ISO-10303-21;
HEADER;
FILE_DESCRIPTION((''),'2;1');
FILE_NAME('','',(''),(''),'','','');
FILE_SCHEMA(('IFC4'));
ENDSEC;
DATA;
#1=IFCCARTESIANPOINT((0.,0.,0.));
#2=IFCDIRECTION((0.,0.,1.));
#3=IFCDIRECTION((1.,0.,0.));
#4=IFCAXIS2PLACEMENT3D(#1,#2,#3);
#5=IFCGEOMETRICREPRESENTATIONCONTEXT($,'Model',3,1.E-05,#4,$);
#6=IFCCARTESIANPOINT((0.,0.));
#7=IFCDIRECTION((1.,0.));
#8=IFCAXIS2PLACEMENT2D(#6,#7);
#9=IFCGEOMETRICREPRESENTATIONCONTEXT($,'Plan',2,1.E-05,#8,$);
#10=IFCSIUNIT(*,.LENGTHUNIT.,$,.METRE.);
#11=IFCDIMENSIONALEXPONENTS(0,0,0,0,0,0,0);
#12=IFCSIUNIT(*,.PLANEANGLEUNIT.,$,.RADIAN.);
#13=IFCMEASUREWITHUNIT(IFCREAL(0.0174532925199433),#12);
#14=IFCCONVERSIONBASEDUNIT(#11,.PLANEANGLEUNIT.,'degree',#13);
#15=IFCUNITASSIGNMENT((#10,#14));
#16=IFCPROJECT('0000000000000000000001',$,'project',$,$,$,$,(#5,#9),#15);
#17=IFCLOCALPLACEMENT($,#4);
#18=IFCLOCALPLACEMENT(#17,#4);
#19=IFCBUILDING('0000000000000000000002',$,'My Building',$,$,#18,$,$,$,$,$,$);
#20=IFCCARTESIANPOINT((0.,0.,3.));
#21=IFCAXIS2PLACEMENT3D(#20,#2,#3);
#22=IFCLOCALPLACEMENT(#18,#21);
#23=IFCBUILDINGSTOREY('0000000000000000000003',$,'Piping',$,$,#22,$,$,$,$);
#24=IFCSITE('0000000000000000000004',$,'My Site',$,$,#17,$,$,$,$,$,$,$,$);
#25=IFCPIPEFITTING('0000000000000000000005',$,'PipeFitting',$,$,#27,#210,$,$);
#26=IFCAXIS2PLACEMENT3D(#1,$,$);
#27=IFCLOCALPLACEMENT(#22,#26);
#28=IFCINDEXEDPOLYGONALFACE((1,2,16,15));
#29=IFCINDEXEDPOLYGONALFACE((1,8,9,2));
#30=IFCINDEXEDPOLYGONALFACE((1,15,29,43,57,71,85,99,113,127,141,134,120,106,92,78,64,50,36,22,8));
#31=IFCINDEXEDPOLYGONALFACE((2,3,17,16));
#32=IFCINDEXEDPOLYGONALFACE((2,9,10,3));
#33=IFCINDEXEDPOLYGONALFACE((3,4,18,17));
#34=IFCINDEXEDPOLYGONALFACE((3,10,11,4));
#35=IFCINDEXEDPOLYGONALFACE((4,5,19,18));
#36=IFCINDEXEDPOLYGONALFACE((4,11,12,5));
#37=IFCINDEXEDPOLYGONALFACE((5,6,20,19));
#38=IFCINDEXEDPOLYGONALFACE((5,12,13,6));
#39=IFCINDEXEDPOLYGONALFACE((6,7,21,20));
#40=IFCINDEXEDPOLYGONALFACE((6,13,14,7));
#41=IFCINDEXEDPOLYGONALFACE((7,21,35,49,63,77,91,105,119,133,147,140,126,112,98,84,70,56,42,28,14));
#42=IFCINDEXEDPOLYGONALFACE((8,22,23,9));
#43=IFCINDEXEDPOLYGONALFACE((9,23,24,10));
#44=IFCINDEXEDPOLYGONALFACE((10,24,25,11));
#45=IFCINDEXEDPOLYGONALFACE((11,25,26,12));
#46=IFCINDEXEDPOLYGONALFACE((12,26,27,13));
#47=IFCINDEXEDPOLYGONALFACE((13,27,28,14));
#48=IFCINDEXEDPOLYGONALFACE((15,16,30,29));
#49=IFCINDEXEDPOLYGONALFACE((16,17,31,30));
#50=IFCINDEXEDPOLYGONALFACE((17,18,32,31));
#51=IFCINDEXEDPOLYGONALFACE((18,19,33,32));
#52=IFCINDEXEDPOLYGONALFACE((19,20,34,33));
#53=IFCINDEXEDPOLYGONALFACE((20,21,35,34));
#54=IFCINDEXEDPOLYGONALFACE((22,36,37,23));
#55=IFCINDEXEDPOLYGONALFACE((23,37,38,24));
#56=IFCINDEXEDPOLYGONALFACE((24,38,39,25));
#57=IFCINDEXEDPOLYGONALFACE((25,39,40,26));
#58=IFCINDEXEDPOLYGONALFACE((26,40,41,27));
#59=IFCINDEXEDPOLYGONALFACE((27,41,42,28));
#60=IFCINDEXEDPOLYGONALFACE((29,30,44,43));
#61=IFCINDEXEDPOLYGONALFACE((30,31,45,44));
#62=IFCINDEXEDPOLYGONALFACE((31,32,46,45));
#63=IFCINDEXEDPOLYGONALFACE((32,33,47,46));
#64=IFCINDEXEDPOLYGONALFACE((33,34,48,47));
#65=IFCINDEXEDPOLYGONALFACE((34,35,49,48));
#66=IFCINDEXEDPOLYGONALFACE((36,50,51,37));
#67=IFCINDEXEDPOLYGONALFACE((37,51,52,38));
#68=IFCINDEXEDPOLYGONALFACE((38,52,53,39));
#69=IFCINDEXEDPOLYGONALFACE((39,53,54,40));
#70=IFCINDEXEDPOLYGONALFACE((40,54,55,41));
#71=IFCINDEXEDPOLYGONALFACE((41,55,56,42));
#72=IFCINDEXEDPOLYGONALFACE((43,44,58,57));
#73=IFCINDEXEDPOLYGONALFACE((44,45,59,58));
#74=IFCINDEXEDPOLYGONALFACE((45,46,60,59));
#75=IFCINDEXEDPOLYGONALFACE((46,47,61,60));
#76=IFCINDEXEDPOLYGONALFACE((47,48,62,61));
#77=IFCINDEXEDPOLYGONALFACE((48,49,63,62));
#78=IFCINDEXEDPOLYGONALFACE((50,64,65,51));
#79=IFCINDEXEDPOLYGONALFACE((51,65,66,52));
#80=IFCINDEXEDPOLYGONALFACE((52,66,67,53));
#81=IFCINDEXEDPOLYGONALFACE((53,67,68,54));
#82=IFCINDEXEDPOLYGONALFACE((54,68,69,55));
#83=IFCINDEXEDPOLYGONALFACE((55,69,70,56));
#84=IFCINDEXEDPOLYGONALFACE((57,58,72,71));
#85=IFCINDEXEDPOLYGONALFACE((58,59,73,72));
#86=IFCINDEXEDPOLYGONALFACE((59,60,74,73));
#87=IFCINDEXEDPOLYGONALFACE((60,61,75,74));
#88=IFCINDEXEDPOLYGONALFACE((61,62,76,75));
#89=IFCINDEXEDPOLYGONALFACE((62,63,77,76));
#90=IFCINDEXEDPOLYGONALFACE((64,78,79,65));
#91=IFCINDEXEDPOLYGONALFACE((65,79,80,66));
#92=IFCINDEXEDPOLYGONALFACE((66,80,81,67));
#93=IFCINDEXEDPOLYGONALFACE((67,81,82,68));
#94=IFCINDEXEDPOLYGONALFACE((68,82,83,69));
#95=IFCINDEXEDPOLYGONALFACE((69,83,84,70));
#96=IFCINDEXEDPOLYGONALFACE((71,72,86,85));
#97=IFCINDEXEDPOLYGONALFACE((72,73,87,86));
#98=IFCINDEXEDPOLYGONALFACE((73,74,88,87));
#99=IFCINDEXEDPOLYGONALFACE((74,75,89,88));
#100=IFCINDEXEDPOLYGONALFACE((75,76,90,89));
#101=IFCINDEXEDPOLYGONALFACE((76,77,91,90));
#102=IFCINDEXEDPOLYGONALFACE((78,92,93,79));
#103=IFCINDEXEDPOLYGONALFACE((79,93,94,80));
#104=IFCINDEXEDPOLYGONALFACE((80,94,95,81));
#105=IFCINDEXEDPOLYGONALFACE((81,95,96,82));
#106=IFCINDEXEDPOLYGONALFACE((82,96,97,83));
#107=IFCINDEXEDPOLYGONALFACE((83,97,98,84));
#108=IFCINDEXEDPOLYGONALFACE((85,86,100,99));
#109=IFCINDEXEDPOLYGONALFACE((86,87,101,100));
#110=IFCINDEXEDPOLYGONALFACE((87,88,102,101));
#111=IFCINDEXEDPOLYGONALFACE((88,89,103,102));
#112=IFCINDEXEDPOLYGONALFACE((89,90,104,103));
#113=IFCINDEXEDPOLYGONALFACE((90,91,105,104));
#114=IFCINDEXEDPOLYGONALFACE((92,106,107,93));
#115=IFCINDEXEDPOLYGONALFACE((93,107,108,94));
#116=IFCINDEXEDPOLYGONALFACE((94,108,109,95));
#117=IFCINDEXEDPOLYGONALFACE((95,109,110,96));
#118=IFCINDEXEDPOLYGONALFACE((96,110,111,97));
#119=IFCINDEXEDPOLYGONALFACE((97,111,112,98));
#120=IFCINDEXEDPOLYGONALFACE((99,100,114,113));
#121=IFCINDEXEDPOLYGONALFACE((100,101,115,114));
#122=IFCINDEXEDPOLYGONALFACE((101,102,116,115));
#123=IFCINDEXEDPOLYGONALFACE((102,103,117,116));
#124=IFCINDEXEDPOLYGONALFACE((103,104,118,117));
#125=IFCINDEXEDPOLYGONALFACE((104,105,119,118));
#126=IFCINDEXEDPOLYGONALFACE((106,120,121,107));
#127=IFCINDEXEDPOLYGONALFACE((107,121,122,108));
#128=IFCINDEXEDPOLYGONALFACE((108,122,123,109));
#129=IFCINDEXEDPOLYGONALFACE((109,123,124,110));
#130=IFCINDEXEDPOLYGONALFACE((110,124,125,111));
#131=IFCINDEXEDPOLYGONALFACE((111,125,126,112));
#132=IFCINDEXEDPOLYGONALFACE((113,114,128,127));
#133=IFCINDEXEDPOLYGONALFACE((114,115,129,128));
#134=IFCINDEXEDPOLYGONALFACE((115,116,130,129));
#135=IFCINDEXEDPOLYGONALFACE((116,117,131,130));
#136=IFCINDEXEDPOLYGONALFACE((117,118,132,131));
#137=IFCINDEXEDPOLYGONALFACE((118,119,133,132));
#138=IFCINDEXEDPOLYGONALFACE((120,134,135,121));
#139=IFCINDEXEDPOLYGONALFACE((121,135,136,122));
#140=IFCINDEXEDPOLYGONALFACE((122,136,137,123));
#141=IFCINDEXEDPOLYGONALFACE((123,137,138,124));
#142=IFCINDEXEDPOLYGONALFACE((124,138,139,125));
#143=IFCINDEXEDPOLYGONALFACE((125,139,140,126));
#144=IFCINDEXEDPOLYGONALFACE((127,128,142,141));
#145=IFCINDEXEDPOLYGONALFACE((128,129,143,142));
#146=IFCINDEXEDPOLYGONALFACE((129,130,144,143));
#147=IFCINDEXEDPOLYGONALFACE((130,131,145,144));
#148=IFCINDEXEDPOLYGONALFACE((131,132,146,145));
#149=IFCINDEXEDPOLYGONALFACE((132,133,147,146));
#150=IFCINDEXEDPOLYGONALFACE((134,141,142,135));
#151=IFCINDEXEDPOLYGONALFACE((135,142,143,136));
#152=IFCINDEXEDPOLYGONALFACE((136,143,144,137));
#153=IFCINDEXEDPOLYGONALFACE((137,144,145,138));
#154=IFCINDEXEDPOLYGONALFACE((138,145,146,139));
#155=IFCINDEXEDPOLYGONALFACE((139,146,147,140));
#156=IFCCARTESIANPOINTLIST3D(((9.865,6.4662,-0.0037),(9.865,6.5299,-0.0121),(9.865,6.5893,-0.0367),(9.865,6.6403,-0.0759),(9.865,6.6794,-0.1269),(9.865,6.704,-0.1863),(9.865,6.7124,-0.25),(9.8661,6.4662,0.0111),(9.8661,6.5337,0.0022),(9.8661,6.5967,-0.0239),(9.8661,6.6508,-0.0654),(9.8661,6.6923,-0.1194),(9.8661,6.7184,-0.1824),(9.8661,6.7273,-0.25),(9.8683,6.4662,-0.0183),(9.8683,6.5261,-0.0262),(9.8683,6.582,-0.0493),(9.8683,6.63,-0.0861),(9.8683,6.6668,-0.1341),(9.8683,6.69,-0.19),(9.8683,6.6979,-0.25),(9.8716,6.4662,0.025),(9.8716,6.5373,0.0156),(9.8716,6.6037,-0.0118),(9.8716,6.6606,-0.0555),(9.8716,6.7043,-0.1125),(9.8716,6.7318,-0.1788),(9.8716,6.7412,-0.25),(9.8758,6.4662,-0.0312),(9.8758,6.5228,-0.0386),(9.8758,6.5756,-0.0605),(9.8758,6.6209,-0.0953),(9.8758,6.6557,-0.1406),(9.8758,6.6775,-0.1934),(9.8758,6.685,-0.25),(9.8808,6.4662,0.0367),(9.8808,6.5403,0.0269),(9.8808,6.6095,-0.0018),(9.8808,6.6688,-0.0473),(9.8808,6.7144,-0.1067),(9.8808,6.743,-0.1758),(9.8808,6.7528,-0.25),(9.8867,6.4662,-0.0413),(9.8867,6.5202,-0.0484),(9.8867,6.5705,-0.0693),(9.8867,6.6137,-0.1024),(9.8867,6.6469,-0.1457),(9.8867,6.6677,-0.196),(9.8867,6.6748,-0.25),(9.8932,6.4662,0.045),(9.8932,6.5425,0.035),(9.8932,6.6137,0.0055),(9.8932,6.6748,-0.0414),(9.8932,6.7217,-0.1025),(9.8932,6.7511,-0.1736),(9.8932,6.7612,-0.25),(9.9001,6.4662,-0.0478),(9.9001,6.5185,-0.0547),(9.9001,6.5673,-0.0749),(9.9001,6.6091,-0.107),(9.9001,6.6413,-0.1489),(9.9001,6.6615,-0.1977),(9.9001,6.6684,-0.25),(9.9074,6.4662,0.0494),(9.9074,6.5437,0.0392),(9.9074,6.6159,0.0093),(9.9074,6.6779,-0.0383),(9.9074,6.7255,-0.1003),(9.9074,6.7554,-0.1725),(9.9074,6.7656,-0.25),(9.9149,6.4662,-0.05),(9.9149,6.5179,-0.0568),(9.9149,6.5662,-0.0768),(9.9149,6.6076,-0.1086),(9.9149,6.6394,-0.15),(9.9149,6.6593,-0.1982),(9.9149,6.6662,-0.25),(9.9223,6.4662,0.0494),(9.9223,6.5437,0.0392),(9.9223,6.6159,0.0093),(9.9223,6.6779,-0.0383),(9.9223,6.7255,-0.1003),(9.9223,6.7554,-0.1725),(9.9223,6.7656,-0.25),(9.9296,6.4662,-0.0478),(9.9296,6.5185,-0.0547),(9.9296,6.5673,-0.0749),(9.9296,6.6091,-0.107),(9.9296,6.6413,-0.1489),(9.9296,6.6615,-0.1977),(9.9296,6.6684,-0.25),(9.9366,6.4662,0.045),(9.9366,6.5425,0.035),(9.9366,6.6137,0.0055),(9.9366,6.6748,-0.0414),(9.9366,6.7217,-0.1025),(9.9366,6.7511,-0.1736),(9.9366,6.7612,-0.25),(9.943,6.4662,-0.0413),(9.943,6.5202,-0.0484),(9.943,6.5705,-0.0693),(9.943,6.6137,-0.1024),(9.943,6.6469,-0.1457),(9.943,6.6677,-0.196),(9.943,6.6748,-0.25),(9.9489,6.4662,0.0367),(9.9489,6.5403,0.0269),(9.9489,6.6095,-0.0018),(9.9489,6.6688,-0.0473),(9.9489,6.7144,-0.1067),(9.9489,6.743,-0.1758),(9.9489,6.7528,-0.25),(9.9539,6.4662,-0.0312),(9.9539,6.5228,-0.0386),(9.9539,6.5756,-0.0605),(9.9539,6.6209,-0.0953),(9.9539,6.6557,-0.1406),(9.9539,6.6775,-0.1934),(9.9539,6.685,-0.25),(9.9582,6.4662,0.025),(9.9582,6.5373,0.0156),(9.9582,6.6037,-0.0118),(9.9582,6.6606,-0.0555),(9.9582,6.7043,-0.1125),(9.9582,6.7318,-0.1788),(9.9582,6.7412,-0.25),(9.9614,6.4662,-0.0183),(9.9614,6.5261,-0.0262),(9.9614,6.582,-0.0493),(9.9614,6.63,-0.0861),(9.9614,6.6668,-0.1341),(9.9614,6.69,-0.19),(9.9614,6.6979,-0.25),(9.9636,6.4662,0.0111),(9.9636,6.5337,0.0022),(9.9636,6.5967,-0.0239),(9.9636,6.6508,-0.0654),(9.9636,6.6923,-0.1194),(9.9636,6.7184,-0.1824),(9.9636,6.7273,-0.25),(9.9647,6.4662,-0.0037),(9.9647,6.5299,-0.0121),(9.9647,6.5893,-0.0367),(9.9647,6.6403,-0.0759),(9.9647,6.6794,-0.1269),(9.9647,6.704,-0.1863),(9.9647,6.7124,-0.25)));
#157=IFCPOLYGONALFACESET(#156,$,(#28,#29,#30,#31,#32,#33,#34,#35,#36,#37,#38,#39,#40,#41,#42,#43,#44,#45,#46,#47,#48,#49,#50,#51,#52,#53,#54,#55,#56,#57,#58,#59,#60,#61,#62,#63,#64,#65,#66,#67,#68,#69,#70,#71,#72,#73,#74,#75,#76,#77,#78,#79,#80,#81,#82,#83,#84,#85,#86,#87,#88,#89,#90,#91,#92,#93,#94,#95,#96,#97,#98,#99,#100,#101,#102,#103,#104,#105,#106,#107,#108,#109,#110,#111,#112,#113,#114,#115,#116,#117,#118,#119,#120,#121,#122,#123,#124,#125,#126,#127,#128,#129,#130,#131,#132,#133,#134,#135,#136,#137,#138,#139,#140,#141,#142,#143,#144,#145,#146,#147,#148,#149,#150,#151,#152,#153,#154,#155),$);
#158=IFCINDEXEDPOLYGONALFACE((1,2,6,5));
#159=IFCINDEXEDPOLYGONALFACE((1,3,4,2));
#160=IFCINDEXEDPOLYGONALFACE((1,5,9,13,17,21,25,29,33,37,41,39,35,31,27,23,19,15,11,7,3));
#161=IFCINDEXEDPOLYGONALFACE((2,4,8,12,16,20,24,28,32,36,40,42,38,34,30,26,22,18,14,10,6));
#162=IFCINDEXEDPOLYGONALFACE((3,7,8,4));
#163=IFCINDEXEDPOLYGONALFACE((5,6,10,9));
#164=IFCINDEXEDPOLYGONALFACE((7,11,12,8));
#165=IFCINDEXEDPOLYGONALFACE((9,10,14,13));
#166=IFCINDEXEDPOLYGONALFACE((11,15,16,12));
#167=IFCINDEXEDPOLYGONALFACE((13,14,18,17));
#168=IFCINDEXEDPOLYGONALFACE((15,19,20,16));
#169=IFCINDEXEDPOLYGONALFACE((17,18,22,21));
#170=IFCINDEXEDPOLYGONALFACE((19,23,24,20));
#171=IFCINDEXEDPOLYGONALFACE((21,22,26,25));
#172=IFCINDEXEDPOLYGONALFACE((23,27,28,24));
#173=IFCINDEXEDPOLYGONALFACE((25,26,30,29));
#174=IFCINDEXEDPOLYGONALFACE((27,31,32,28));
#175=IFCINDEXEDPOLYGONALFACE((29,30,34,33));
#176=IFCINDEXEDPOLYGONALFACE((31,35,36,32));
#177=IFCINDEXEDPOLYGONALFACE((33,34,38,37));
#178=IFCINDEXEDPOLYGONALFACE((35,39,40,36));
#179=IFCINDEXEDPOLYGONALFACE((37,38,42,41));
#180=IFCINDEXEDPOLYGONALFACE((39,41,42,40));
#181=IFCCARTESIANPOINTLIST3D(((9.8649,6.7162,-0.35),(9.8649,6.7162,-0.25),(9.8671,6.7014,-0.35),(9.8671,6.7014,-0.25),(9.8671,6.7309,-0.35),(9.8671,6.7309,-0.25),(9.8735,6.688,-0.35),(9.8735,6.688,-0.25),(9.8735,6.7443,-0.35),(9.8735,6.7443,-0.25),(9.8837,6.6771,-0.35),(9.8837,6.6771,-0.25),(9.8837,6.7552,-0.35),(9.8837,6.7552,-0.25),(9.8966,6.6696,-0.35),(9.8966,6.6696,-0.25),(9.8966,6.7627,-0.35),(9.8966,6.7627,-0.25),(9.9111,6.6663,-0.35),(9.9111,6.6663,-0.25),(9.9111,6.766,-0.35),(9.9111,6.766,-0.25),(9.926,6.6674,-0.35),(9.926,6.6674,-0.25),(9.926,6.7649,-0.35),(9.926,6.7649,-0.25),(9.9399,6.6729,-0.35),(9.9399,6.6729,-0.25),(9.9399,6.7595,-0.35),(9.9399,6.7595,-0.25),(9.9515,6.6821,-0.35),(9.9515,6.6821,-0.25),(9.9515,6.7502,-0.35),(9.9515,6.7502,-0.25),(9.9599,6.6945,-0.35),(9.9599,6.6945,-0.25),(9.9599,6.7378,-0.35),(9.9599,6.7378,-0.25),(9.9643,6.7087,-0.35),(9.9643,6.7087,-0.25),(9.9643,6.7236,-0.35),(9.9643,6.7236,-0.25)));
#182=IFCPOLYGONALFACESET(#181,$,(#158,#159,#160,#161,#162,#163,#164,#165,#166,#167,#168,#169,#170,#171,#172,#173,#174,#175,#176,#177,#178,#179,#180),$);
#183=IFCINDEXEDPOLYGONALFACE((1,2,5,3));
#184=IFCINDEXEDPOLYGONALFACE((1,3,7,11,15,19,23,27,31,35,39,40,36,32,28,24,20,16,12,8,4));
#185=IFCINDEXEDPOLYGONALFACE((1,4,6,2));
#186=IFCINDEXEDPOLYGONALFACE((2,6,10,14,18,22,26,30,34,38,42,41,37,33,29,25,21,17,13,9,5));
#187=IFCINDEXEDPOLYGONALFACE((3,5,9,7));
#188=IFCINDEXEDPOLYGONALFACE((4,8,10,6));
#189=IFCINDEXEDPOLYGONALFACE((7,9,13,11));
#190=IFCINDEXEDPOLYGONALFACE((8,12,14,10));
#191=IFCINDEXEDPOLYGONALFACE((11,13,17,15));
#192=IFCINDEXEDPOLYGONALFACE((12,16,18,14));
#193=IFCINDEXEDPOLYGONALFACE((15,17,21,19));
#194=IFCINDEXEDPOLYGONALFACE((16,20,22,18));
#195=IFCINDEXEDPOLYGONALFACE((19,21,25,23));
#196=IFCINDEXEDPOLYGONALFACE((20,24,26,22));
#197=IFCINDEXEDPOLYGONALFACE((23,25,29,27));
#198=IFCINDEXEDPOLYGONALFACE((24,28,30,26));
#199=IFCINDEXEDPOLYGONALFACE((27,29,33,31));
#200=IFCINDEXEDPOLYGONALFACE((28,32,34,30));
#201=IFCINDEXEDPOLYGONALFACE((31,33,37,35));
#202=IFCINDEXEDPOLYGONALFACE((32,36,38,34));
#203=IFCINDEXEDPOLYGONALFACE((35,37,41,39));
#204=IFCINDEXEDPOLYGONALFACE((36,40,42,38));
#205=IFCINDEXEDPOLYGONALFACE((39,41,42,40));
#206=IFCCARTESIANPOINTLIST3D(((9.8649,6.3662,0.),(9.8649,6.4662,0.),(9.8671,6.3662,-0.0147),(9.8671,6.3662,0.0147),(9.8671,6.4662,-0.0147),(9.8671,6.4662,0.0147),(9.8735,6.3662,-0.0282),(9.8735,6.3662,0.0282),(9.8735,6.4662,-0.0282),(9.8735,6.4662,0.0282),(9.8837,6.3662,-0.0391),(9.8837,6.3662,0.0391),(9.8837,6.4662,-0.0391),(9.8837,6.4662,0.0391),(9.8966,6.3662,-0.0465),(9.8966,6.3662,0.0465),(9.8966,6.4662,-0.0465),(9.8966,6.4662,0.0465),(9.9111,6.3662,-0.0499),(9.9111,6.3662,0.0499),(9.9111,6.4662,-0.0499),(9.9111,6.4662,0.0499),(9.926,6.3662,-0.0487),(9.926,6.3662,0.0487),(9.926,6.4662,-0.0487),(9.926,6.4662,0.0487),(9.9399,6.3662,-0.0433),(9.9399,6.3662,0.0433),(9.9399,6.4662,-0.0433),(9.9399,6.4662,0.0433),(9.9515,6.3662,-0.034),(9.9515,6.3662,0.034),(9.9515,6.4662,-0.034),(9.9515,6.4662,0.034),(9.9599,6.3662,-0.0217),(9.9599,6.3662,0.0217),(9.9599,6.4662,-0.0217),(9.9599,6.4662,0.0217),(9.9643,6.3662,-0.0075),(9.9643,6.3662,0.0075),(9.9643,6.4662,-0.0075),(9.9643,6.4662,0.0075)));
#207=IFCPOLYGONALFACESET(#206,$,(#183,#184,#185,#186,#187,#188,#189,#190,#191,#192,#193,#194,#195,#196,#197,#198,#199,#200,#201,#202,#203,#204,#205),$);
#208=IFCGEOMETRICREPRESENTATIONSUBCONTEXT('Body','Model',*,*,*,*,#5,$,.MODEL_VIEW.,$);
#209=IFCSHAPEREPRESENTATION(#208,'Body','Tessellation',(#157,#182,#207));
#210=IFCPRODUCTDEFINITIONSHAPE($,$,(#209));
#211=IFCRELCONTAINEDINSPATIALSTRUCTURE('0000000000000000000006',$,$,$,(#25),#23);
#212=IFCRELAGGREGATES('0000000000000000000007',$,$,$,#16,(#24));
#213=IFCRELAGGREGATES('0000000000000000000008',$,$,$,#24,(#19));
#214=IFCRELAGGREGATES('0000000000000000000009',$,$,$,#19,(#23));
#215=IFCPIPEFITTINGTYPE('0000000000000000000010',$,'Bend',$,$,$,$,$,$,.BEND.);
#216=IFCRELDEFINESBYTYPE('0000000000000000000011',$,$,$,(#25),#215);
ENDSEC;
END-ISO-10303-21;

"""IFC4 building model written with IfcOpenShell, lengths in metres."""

from ifc_helpers import new_model, entity, si_unit, converted_unit, frame, origin_with_axes, origin_2d_with_axis, place, context, subcontext, project, spatial, circle, extrude, source, transform, mapped, type_object, type_shapes, element, save


model = new_model("IFC4")

# Units and contexts
model_context = context("Model", 3, precision=1e-05, world=origin_with_axes())
plan_context = context("Plan", 2, precision=1e-05, world=origin_2d_with_axis())
body_context = subcontext(model_context, "Body", "Model", "MODEL_VIEW")
ifc_project = project(units=[si_unit("LENGTHUNIT", "METRE"), converted_unit("PLANEANGLEUNIT", "degree", entity("IfcReal", 0.0174532925199433), si_unit("PLANEANGLEUNIT", "RADIAN"), dimensions=[0, 0, 0, 0, 0, 0, 0])], contexts=[model_context, plan_context])

# Site, building, storey
site_placement = place(None, origin_with_axes())
site = spatial("IfcSite", under=ifc_project, at=site_placement, Name="My Site")
building_placement = place(site_placement, origin_with_axes())
building = spatial("IfcBuilding", under=site, at=building_placement, Name="My Building")
storey_placement = place(building_placement, frame((0.0, 0.0, 3.0), z_axis=(0.0, 0.0, 1.0), x_axis=(1.0, 0.0, 0.0)))
storey = spatial("IfcBuildingStorey", under=building, at=storey_placement, Name="Piping")

# Pipe fitting
pipe_fitting_type = type_object("IfcPipeFittingType", Name="Bend", PredefinedType="BEND")
shared_shape = source(origin_with_axes(), body_context, "Body", "SolidModel", [
    entity("IfcSweptDiskSolid", entity("IfcIndexedPolyCurve", entity("IfcCartesianPointList3D", [[0.0, 0.0, -0.1], [0.0, -0.0732, -0.2768], [0.0, -0.25, -0.35]]), [entity("IfcArcIndex", [1, 2, 3])]), 0.05),
    extrude(circle(Radius=0.05), origin_with_axes(), (0.0, 0.0, -1.0), 0.1),
    extrude(circle(Radius=0.05), frame((0.0, -0.25, -0.35), z_axis=(0.0, -1.0, 0.0), x_axis=(1.0, 0.0, 0.0)), (0.0, 0.0, 1.0), 0.1),
])
type_shapes(pipe_fitting_type, [shared_shape])
for number, where, z_axis, x_axis, name in (
    (1, (9.9149, 6.7162, -0.35), (0.0, 0.0, -1.0), (-1.0, 0.0, 0.0), "PipeFitting"),
):
    element("IfcPipeFitting", number, at=place(storey_placement, frame(where, z_axis=z_axis, x_axis=x_axis)), inside=storey, type_object=pipe_fitting_type, Name=name, context=body_context, shape_type="MappedRepresentation", body=[
        mapped(shared_shape, transform((0.0, 0.0, 0.0), x_axis=(1.0, 0.0, 0.0), y_axis=(0.0, 1.0, 0.0), z_axis=(0.0, 0.0, 1.0), scale=1.0)),
    ])

save(model, "model.ifc")
